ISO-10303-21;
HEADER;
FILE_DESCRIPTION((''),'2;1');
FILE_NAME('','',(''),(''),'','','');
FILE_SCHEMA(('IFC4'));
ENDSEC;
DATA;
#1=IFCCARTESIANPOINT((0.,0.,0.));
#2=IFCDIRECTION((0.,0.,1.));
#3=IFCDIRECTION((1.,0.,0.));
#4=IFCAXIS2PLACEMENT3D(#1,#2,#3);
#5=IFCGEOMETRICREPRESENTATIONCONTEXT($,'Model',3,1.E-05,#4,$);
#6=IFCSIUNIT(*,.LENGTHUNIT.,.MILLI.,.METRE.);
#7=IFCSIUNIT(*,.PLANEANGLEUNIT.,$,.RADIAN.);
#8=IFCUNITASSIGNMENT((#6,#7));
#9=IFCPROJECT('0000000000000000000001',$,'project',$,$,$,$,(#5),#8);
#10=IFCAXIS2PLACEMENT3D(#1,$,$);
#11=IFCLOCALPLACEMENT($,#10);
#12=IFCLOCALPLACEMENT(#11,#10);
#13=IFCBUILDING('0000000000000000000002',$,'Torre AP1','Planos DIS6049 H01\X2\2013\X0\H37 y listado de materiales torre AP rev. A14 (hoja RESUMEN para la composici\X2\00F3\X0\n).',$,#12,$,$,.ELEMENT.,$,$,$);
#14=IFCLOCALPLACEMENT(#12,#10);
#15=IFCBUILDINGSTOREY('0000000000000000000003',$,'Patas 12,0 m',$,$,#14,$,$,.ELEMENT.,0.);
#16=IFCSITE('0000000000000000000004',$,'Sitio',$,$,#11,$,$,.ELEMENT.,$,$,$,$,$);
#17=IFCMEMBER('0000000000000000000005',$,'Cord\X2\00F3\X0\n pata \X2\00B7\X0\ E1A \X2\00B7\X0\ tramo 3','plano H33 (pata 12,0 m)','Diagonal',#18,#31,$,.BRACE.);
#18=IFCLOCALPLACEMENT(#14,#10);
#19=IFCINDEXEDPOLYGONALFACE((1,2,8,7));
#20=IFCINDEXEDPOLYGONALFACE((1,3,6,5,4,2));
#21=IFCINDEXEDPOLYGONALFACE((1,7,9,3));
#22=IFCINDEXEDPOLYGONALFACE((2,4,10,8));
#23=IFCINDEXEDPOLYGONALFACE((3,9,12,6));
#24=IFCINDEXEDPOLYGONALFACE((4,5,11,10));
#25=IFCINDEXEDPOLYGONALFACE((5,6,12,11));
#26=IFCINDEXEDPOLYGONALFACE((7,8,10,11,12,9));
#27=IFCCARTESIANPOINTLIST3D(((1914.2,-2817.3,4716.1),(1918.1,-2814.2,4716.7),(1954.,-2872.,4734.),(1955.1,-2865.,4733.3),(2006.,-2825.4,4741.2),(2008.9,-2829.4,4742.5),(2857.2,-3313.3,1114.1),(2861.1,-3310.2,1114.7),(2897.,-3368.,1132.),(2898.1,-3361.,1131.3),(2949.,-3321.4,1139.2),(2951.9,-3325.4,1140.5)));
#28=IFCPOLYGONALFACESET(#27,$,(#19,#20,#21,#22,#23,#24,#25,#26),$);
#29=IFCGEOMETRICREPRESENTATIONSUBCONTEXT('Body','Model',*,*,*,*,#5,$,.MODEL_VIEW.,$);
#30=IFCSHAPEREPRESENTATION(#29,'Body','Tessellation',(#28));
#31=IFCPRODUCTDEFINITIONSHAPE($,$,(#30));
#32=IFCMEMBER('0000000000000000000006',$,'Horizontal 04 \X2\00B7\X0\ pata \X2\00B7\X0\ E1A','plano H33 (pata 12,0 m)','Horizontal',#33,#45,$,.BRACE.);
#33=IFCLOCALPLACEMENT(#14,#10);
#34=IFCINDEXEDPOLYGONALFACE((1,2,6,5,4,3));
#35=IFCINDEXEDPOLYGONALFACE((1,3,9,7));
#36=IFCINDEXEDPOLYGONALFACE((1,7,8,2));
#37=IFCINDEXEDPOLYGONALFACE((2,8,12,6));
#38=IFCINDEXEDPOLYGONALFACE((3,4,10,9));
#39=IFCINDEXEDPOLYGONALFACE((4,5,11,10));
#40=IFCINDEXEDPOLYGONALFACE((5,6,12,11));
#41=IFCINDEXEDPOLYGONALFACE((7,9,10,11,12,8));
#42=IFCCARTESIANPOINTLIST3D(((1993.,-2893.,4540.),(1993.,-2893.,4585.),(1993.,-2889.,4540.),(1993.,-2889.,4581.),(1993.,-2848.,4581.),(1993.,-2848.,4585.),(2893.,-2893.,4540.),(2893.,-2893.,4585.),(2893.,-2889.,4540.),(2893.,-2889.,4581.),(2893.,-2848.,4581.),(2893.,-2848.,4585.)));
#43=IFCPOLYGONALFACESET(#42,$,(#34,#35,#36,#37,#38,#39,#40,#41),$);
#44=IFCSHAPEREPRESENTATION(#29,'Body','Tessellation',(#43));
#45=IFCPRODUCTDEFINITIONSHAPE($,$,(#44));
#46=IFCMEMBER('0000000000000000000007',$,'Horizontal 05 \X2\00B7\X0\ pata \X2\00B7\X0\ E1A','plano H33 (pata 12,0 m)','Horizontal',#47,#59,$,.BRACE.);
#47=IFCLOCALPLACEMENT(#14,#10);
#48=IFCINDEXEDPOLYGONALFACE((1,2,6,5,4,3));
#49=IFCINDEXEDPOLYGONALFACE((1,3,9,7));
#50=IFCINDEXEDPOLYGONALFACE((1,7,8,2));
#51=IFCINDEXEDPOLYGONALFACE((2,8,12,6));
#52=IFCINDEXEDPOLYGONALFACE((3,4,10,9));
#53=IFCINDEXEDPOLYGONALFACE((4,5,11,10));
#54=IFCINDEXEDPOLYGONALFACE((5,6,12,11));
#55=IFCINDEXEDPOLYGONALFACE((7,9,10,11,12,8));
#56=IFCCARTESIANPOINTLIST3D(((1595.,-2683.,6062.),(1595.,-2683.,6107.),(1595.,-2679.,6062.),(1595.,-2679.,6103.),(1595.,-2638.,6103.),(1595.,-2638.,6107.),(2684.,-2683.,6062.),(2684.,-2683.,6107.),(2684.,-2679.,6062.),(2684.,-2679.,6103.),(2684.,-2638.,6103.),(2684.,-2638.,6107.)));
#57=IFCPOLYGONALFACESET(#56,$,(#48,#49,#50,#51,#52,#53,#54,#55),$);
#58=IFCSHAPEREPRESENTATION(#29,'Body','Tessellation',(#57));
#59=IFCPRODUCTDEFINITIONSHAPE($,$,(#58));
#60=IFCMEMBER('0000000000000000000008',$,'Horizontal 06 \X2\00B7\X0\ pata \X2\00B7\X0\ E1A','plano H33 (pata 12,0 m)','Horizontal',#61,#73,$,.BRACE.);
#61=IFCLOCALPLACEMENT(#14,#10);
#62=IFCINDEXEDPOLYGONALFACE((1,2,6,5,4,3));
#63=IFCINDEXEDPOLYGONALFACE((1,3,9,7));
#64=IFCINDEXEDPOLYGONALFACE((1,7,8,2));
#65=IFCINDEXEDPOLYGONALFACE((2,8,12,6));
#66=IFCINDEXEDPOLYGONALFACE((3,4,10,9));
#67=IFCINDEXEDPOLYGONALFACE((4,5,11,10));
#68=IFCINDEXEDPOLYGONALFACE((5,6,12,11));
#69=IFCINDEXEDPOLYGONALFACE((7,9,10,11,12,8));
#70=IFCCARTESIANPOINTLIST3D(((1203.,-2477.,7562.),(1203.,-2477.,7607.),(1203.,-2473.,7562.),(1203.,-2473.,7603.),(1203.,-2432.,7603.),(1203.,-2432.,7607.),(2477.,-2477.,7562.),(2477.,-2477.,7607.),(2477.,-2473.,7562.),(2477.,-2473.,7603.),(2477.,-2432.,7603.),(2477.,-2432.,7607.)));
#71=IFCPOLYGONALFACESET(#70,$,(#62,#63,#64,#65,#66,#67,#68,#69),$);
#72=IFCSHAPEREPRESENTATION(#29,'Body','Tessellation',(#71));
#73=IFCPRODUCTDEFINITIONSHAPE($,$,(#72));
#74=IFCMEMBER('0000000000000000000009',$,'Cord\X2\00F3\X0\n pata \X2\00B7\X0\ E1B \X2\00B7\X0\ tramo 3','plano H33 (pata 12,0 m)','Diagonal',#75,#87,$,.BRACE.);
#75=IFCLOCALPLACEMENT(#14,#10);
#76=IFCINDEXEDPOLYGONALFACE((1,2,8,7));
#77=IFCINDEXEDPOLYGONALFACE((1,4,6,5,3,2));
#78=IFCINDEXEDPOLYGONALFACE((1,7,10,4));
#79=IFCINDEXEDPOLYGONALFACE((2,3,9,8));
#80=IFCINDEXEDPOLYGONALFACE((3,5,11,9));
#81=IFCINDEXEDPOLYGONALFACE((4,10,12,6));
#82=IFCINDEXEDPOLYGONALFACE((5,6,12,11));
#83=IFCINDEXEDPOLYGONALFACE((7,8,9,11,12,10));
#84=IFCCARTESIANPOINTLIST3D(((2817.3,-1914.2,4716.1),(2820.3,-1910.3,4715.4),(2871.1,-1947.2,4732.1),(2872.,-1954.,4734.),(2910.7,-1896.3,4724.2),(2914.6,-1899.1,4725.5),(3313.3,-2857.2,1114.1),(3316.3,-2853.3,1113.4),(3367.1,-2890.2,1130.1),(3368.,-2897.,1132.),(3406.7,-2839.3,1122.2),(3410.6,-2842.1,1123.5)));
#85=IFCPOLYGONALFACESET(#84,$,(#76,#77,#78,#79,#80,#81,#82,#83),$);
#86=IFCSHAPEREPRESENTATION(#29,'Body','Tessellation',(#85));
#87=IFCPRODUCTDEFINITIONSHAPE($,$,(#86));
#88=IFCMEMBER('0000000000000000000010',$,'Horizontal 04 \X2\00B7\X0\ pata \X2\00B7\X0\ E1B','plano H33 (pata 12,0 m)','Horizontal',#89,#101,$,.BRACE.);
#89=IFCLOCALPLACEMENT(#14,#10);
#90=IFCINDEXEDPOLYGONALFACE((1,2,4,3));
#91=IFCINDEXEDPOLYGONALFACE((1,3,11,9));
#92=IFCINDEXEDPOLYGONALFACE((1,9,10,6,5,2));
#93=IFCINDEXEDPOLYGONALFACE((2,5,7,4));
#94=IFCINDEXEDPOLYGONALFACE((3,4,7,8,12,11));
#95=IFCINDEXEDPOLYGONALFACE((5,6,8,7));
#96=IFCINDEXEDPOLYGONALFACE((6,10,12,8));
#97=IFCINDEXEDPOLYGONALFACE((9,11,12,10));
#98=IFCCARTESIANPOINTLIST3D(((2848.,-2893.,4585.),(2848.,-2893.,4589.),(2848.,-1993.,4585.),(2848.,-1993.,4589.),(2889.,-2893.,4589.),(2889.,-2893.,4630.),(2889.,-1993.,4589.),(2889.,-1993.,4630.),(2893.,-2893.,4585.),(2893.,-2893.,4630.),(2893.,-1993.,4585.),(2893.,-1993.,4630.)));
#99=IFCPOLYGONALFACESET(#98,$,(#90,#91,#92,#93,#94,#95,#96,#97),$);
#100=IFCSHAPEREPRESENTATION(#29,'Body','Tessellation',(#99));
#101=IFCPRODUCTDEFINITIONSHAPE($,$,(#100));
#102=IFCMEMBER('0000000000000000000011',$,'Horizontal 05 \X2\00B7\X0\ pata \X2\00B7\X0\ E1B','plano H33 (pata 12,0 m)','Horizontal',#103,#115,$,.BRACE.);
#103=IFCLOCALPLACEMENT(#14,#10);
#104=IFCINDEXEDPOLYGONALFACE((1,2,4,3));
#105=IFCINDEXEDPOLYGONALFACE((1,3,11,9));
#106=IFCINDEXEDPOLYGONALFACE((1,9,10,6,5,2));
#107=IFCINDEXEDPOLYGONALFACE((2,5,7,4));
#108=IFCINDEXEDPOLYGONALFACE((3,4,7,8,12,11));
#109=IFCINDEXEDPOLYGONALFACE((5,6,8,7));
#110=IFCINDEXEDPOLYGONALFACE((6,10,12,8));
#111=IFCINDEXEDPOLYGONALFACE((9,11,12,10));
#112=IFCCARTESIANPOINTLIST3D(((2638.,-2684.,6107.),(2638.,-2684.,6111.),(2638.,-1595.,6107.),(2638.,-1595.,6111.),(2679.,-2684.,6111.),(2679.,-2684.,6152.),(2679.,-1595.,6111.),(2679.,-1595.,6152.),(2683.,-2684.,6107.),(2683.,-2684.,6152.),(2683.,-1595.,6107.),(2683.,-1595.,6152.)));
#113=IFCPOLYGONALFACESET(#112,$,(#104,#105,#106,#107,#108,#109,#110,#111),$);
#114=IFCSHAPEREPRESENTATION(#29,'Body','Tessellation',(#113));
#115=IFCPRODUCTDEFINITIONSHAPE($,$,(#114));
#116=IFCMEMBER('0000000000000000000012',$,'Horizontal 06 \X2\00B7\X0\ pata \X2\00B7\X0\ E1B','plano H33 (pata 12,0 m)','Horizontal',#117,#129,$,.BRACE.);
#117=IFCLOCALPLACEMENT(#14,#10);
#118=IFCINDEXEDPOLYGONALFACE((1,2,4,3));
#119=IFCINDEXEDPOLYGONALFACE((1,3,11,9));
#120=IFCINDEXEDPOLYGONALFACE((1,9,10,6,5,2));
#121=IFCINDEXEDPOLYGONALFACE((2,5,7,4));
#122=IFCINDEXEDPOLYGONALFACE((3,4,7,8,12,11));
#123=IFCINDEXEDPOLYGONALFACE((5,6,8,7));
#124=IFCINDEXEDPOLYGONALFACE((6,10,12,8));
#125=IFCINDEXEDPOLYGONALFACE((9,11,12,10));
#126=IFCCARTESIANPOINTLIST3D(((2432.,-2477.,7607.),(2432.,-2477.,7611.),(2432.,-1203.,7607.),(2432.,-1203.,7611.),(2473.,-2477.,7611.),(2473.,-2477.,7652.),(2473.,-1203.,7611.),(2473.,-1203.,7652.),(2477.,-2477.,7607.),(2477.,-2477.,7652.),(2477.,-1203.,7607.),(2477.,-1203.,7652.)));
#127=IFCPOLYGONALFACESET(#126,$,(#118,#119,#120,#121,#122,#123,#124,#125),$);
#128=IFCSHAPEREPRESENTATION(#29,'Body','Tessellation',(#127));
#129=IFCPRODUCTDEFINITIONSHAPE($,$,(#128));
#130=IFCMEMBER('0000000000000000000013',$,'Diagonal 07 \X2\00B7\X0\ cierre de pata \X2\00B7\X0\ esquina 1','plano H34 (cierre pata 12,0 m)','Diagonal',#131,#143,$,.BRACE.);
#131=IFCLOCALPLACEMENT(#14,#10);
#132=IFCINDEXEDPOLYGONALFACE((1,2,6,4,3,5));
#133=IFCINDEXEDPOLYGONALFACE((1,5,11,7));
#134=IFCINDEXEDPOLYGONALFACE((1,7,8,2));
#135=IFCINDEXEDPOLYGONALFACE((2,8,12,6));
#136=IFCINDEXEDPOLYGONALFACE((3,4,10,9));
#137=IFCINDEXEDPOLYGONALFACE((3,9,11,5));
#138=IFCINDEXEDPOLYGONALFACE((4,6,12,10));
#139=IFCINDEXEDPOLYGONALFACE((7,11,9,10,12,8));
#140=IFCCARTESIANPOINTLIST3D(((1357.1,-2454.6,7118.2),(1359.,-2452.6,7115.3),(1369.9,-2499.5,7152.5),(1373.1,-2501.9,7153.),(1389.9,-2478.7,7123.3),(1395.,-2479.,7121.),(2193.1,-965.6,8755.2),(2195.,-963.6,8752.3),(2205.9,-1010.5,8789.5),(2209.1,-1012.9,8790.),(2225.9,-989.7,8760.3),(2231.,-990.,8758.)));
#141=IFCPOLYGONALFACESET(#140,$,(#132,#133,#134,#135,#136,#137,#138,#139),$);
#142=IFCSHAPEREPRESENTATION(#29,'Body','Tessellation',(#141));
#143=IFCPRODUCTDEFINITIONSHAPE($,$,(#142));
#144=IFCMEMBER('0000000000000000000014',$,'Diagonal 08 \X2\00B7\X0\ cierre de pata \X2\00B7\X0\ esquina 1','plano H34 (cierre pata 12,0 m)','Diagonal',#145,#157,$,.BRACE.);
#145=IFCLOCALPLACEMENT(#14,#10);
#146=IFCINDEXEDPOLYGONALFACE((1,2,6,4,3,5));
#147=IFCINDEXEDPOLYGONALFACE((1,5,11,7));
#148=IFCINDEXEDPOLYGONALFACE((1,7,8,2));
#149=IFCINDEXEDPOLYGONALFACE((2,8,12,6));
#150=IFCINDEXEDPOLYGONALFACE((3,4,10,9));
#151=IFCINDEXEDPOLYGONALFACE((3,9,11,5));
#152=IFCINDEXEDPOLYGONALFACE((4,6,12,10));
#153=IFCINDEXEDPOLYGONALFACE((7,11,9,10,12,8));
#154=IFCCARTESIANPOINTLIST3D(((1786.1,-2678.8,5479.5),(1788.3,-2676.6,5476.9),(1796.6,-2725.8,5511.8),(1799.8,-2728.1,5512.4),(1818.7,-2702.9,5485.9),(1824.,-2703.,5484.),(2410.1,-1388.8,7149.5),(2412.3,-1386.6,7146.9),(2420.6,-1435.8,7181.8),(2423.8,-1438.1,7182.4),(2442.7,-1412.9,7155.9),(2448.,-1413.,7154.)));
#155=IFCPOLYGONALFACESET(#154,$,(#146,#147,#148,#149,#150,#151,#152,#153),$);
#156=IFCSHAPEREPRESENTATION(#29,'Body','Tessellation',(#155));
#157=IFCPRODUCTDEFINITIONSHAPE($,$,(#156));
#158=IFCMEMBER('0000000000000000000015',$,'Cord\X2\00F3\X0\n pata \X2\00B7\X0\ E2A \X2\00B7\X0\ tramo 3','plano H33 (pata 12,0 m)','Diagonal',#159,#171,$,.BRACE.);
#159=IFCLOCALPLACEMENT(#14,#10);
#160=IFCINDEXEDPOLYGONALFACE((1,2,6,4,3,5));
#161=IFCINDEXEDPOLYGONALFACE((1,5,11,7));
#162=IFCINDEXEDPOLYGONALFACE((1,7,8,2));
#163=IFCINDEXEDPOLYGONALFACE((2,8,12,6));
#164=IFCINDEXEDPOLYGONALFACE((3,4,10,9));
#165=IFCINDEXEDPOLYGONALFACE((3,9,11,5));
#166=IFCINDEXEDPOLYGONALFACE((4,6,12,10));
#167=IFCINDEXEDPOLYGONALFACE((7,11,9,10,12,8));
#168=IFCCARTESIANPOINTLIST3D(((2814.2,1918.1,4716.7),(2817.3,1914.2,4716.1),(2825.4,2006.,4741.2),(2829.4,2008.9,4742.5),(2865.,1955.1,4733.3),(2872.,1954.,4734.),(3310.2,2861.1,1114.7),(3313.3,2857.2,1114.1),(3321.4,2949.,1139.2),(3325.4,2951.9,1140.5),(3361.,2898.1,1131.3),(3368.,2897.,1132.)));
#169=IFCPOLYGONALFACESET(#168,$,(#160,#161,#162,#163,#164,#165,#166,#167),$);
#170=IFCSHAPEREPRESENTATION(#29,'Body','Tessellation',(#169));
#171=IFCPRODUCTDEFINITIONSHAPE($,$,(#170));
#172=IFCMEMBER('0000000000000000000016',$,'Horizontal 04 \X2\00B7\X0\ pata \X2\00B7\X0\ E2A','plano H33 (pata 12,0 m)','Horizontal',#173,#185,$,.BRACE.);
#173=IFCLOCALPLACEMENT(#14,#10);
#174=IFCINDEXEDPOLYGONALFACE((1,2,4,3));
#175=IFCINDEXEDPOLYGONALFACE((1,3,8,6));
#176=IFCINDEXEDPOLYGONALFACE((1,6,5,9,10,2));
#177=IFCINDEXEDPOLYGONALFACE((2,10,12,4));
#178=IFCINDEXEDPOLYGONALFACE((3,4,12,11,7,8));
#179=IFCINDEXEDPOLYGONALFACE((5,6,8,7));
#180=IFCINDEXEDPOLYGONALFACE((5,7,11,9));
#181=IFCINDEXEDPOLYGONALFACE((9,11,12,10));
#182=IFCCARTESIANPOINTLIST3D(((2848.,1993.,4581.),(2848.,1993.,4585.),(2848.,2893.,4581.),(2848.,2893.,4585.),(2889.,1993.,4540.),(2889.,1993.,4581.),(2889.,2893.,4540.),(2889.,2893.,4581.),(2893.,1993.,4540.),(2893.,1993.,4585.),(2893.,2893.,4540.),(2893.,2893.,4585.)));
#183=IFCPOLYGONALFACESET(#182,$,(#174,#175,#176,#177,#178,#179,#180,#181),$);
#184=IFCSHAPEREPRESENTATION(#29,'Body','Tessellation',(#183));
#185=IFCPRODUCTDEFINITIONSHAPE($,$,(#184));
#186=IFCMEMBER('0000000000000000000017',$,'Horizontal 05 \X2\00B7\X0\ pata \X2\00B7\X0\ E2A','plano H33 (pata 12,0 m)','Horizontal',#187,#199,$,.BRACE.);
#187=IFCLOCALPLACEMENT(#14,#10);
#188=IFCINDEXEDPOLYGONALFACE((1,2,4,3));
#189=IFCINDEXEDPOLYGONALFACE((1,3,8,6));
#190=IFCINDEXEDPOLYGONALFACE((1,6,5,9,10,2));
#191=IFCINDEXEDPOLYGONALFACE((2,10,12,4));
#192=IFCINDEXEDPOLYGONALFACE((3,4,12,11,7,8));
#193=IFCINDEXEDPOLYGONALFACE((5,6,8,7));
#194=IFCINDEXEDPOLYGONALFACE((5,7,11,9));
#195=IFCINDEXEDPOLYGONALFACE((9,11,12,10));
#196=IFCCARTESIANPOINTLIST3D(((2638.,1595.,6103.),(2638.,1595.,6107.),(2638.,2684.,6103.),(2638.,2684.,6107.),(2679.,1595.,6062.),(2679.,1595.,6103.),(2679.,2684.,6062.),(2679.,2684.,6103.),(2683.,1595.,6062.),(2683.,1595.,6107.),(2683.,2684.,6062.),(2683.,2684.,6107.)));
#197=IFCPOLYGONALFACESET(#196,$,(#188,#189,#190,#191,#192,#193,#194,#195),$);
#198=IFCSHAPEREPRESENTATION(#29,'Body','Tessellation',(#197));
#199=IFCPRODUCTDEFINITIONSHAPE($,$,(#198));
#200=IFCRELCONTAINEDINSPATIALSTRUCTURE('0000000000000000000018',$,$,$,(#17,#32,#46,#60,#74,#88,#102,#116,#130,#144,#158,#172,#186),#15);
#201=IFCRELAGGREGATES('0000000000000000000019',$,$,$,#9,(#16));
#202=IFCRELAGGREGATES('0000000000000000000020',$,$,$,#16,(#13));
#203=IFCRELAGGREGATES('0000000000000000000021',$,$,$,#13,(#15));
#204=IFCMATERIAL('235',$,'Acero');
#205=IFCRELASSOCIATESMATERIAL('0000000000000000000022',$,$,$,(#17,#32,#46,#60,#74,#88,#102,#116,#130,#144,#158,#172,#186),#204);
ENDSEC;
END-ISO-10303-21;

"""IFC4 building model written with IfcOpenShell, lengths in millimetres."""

from ifc_helpers import new_model, si_unit, frame, frame_2d, origin, origin_with_axes, place, context, subcontext, project, spatial, l_section, extrude, material, element, save


model = new_model("IFC4")

# Units and contexts
model_context = context("Model", 3, precision=1e-05, world=origin_with_axes())
body_context = subcontext(model_context, "Body", "Model", "MODEL_VIEW")
ifc_project = project(units=[si_unit("LENGTHUNIT", "METRE", prefix="MILLI"), si_unit("PLANEANGLEUNIT", "RADIAN")], contexts=[model_context])

# Site, building, storey
site_placement = place(None, origin())
site = spatial("IfcSite", under=ifc_project, at=site_placement, Name="Sitio", CompositionType="ELEMENT")
building_placement = place(site_placement, origin())
building = spatial("IfcBuilding", under=site, at=building_placement, Name="Torre AP1", Description="Planos DIS6049 H01–H37 y listado de materiales torre AP rev. A14 (hoja RESUMEN para la composición).", CompositionType="ELEMENT")
storey_placement = place(building_placement, origin())
storey = spatial("IfcBuildingStorey", under=building, at=storey_placement, Name="Patas 12,0 m", CompositionType="ELEMENT", Elevation=0.0)

# Members
ifc_material = material(Name="235", Category="Acero")
member_1_placement = place(storey_placement, frame((1954.0, -2872.0, 4734.0), z_axis=(0.251046, -0.132045, -0.958926), x_axis=(-0.56819, 0.781925, -0.256424)))
element("IfcMember", 1, at=member_1_placement, inside=storey, material=ifc_material, Name="Cordón pata · E1A · tramo 3", Description="plano H33 (pata 12,0 m)", ObjectType="Diagonal", PredefinedType="BRACE", context=body_context, shape_type="SweptSolid", body=[
    extrude(l_section(Depth=70.0, Width=70.0, Thickness=5.0, at=frame_2d((35.0, 35.0))), None, (0.0, 0.0, 1.0), 3756.3),
])
member_2_placement = place(storey_placement, frame((2893.0, -2893.0, 4585.0), z_axis=(-1.0, 0.0, 0.0), x_axis=(0.0, 1.0, 0.0)))
element("IfcMember", 2, at=member_2_placement, inside=storey, material=ifc_material, Name="Horizontal 04 · pata · E1A", Description="plano H33 (pata 12,0 m)", ObjectType="Horizontal", PredefinedType="BRACE", context=body_context, shape_type="SweptSolid", body=[
    extrude(l_section(Depth=45.0, Width=45.0, Thickness=4.0, at=frame_2d((22.5, 22.5))), None, (0.0, 0.0, 1.0), 900.0),
])
member_3_placement = place(storey_placement, frame((2684.0, -2683.0, 6107.0), z_axis=(-1.0, 0.0, 0.0), x_axis=(0.0, 1.0, 0.0)))
element("IfcMember", 3, at=member_3_placement, inside=storey, material=ifc_material, Name="Horizontal 05 · pata · E1A", Description="plano H33 (pata 12,0 m)", ObjectType="Horizontal", PredefinedType="BRACE", context=body_context, shape_type="SweptSolid", body=[
    extrude(l_section(Depth=45.0, Width=45.0, Thickness=4.0, at=frame_2d((22.5, 22.5))), None, (0.0, 0.0, 1.0), 1089.0),
])
member_4_placement = place(storey_placement, frame((2477.0, -2477.0, 7607.0), z_axis=(-1.0, 0.0, 0.0), x_axis=(0.0, 1.0, 0.0)))
element("IfcMember", 4, at=member_4_placement, inside=storey, material=ifc_material, Name="Horizontal 06 · pata · E1A", Description="plano H33 (pata 12,0 m)", ObjectType="Horizontal", PredefinedType="BRACE", context=body_context, shape_type="SweptSolid", body=[
    extrude(l_section(Depth=45.0, Width=45.0, Thickness=4.0, at=frame_2d((22.5, 22.5))), None, (0.0, 0.0, 1.0), 1274.0),
])
member_5_placement = place(storey_placement, frame((2872.0, -1954.0, 4734.0), z_axis=(0.132045, -0.251046, -0.958926), x_axis=(-0.781925, 0.56819, -0.256424)))
element("IfcMember", 5, at=member_5_placement, inside=storey, material=ifc_material, Name="Cordón pata · E1B · tramo 3", Description="plano H33 (pata 12,0 m)", ObjectType="Diagonal", PredefinedType="BRACE", context=body_context, shape_type="SweptSolid", body=[
    extrude(l_section(Depth=70.0, Width=70.0, Thickness=5.0, at=frame_2d((35.0, 35.0))), None, (0.0, 0.0, 1.0), 3756.3),
])
member_6_placement = place(storey_placement, frame((2893.0, -2893.0, 4585.0), z_axis=(0.0, 1.0, 0.0), x_axis=(-1.0, 0.0, 0.0)))
element("IfcMember", 6, at=member_6_placement, inside=storey, material=ifc_material, Name="Horizontal 04 · pata · E1B", Description="plano H33 (pata 12,0 m)", ObjectType="Horizontal", PredefinedType="BRACE", context=body_context, shape_type="SweptSolid", body=[
    extrude(l_section(Depth=45.0, Width=45.0, Thickness=4.0, at=frame_2d((22.5, 22.5))), None, (0.0, 0.0, 1.0), 900.0),
])
member_7_placement = place(storey_placement, frame((2683.0, -2684.0, 6107.0), z_axis=(0.0, 1.0, 0.0), x_axis=(-1.0, 0.0, 0.0)))
element("IfcMember", 7, at=member_7_placement, inside=storey, material=ifc_material, Name="Horizontal 05 · pata · E1B", Description="plano H33 (pata 12,0 m)", ObjectType="Horizontal", PredefinedType="BRACE", context=body_context, shape_type="SweptSolid", body=[
    extrude(l_section(Depth=45.0, Width=45.0, Thickness=4.0, at=frame_2d((22.5, 22.5))), None, (0.0, 0.0, 1.0), 1089.0),
])
member_8_placement = place(storey_placement, frame((2477.0, -2477.0, 7607.0), z_axis=(0.0, 1.0, 0.0), x_axis=(-1.0, 0.0, 0.0)))
element("IfcMember", 8, at=member_8_placement, inside=storey, material=ifc_material, Name="Horizontal 06 · pata · E1B", Description="plano H33 (pata 12,0 m)", ObjectType="Horizontal", PredefinedType="BRACE", context=body_context, shape_type="SweptSolid", body=[
    extrude(l_section(Depth=45.0, Width=45.0, Thickness=4.0, at=frame_2d((22.5, 22.5))), None, (0.0, 0.0, 1.0), 1274.0),
])
member_9_placement = place(storey_placement, frame((1395.0, -2479.0, 7121.0), z_axis=(0.353407, 0.629454, 0.692019), x_axis=(-0.799129, 0.587707, -0.126466)))
element("IfcMember", 9, at=member_9_placement, inside=storey, material=ifc_material, Name="Diagonal 07 · cierre de pata · esquina 1", Description="plano H34 (cierre pata 12,0 m)", ObjectType="Diagonal", PredefinedType="BRACE", context=body_context, shape_type="SweptSolid", body=[
    extrude(l_section(Depth=45.0, Width=45.0, Thickness=4.0, at=frame_2d((22.5, 22.5))), None, (0.0, 0.0, 1.0), 2365.5),
])
member_10_placement = place(storey_placement, frame((1824.0, -2703.0, 5484.0), z_axis=(0.283567, 0.58622, 0.758905), x_axis=(-0.794021, 0.587278, -0.156957)))
element("IfcMember", 10, at=member_10_placement, inside=storey, material=ifc_material, Name="Diagonal 08 · cierre de pata · esquina 1", Description="plano H34 (cierre pata 12,0 m)", ObjectType="Diagonal", PredefinedType="BRACE", context=body_context, shape_type="SweptSolid", body=[
    extrude(l_section(Depth=45.0, Width=45.0, Thickness=4.0, at=frame_2d((22.5, 22.5))), None, (0.0, 0.0, 1.0), 2200.5),
])
member_11_placement = place(storey_placement, frame((2872.0, 1954.0, 4734.0), z_axis=(0.132045, 0.251046, -0.958926), x_axis=(-0.781925, -0.56819, -0.256424)))
element("IfcMember", 11, at=member_11_placement, inside=storey, material=ifc_material, Name="Cordón pata · E2A · tramo 3", Description="plano H33 (pata 12,0 m)", ObjectType="Diagonal", PredefinedType="BRACE", context=body_context, shape_type="SweptSolid", body=[
    extrude(l_section(Depth=70.0, Width=70.0, Thickness=5.0, at=frame_2d((35.0, 35.0))), None, (0.0, 0.0, 1.0), 3756.3),
])
member_12_placement = place(storey_placement, frame((2893.0, 2893.0, 4585.0), z_axis=(0.0, -1.0, 0.0), x_axis=(-1.0, 0.0, 0.0)))
element("IfcMember", 12, at=member_12_placement, inside=storey, material=ifc_material, Name="Horizontal 04 · pata · E2A", Description="plano H33 (pata 12,0 m)", ObjectType="Horizontal", PredefinedType="BRACE", context=body_context, shape_type="SweptSolid", body=[
    extrude(l_section(Depth=45.0, Width=45.0, Thickness=4.0, at=frame_2d((22.5, 22.5))), None, (0.0, 0.0, 1.0), 900.0),
])
member_13_placement = place(storey_placement, frame((2683.0, 2684.0, 6107.0), z_axis=(0.0, -1.0, 0.0), x_axis=(-1.0, 0.0, 0.0)))
element("IfcMember", 13, at=member_13_placement, inside=storey, material=ifc_material, Name="Horizontal 05 · pata · E2A", Description="plano H33 (pata 12,0 m)", ObjectType="Horizontal", PredefinedType="BRACE", context=body_context, shape_type="SweptSolid", body=[
    extrude(l_section(Depth=45.0, Width=45.0, Thickness=4.0, at=frame_2d((22.5, 22.5))), None, (0.0, 0.0, 1.0), 1089.0),
])

save(model, "model.ifc")
